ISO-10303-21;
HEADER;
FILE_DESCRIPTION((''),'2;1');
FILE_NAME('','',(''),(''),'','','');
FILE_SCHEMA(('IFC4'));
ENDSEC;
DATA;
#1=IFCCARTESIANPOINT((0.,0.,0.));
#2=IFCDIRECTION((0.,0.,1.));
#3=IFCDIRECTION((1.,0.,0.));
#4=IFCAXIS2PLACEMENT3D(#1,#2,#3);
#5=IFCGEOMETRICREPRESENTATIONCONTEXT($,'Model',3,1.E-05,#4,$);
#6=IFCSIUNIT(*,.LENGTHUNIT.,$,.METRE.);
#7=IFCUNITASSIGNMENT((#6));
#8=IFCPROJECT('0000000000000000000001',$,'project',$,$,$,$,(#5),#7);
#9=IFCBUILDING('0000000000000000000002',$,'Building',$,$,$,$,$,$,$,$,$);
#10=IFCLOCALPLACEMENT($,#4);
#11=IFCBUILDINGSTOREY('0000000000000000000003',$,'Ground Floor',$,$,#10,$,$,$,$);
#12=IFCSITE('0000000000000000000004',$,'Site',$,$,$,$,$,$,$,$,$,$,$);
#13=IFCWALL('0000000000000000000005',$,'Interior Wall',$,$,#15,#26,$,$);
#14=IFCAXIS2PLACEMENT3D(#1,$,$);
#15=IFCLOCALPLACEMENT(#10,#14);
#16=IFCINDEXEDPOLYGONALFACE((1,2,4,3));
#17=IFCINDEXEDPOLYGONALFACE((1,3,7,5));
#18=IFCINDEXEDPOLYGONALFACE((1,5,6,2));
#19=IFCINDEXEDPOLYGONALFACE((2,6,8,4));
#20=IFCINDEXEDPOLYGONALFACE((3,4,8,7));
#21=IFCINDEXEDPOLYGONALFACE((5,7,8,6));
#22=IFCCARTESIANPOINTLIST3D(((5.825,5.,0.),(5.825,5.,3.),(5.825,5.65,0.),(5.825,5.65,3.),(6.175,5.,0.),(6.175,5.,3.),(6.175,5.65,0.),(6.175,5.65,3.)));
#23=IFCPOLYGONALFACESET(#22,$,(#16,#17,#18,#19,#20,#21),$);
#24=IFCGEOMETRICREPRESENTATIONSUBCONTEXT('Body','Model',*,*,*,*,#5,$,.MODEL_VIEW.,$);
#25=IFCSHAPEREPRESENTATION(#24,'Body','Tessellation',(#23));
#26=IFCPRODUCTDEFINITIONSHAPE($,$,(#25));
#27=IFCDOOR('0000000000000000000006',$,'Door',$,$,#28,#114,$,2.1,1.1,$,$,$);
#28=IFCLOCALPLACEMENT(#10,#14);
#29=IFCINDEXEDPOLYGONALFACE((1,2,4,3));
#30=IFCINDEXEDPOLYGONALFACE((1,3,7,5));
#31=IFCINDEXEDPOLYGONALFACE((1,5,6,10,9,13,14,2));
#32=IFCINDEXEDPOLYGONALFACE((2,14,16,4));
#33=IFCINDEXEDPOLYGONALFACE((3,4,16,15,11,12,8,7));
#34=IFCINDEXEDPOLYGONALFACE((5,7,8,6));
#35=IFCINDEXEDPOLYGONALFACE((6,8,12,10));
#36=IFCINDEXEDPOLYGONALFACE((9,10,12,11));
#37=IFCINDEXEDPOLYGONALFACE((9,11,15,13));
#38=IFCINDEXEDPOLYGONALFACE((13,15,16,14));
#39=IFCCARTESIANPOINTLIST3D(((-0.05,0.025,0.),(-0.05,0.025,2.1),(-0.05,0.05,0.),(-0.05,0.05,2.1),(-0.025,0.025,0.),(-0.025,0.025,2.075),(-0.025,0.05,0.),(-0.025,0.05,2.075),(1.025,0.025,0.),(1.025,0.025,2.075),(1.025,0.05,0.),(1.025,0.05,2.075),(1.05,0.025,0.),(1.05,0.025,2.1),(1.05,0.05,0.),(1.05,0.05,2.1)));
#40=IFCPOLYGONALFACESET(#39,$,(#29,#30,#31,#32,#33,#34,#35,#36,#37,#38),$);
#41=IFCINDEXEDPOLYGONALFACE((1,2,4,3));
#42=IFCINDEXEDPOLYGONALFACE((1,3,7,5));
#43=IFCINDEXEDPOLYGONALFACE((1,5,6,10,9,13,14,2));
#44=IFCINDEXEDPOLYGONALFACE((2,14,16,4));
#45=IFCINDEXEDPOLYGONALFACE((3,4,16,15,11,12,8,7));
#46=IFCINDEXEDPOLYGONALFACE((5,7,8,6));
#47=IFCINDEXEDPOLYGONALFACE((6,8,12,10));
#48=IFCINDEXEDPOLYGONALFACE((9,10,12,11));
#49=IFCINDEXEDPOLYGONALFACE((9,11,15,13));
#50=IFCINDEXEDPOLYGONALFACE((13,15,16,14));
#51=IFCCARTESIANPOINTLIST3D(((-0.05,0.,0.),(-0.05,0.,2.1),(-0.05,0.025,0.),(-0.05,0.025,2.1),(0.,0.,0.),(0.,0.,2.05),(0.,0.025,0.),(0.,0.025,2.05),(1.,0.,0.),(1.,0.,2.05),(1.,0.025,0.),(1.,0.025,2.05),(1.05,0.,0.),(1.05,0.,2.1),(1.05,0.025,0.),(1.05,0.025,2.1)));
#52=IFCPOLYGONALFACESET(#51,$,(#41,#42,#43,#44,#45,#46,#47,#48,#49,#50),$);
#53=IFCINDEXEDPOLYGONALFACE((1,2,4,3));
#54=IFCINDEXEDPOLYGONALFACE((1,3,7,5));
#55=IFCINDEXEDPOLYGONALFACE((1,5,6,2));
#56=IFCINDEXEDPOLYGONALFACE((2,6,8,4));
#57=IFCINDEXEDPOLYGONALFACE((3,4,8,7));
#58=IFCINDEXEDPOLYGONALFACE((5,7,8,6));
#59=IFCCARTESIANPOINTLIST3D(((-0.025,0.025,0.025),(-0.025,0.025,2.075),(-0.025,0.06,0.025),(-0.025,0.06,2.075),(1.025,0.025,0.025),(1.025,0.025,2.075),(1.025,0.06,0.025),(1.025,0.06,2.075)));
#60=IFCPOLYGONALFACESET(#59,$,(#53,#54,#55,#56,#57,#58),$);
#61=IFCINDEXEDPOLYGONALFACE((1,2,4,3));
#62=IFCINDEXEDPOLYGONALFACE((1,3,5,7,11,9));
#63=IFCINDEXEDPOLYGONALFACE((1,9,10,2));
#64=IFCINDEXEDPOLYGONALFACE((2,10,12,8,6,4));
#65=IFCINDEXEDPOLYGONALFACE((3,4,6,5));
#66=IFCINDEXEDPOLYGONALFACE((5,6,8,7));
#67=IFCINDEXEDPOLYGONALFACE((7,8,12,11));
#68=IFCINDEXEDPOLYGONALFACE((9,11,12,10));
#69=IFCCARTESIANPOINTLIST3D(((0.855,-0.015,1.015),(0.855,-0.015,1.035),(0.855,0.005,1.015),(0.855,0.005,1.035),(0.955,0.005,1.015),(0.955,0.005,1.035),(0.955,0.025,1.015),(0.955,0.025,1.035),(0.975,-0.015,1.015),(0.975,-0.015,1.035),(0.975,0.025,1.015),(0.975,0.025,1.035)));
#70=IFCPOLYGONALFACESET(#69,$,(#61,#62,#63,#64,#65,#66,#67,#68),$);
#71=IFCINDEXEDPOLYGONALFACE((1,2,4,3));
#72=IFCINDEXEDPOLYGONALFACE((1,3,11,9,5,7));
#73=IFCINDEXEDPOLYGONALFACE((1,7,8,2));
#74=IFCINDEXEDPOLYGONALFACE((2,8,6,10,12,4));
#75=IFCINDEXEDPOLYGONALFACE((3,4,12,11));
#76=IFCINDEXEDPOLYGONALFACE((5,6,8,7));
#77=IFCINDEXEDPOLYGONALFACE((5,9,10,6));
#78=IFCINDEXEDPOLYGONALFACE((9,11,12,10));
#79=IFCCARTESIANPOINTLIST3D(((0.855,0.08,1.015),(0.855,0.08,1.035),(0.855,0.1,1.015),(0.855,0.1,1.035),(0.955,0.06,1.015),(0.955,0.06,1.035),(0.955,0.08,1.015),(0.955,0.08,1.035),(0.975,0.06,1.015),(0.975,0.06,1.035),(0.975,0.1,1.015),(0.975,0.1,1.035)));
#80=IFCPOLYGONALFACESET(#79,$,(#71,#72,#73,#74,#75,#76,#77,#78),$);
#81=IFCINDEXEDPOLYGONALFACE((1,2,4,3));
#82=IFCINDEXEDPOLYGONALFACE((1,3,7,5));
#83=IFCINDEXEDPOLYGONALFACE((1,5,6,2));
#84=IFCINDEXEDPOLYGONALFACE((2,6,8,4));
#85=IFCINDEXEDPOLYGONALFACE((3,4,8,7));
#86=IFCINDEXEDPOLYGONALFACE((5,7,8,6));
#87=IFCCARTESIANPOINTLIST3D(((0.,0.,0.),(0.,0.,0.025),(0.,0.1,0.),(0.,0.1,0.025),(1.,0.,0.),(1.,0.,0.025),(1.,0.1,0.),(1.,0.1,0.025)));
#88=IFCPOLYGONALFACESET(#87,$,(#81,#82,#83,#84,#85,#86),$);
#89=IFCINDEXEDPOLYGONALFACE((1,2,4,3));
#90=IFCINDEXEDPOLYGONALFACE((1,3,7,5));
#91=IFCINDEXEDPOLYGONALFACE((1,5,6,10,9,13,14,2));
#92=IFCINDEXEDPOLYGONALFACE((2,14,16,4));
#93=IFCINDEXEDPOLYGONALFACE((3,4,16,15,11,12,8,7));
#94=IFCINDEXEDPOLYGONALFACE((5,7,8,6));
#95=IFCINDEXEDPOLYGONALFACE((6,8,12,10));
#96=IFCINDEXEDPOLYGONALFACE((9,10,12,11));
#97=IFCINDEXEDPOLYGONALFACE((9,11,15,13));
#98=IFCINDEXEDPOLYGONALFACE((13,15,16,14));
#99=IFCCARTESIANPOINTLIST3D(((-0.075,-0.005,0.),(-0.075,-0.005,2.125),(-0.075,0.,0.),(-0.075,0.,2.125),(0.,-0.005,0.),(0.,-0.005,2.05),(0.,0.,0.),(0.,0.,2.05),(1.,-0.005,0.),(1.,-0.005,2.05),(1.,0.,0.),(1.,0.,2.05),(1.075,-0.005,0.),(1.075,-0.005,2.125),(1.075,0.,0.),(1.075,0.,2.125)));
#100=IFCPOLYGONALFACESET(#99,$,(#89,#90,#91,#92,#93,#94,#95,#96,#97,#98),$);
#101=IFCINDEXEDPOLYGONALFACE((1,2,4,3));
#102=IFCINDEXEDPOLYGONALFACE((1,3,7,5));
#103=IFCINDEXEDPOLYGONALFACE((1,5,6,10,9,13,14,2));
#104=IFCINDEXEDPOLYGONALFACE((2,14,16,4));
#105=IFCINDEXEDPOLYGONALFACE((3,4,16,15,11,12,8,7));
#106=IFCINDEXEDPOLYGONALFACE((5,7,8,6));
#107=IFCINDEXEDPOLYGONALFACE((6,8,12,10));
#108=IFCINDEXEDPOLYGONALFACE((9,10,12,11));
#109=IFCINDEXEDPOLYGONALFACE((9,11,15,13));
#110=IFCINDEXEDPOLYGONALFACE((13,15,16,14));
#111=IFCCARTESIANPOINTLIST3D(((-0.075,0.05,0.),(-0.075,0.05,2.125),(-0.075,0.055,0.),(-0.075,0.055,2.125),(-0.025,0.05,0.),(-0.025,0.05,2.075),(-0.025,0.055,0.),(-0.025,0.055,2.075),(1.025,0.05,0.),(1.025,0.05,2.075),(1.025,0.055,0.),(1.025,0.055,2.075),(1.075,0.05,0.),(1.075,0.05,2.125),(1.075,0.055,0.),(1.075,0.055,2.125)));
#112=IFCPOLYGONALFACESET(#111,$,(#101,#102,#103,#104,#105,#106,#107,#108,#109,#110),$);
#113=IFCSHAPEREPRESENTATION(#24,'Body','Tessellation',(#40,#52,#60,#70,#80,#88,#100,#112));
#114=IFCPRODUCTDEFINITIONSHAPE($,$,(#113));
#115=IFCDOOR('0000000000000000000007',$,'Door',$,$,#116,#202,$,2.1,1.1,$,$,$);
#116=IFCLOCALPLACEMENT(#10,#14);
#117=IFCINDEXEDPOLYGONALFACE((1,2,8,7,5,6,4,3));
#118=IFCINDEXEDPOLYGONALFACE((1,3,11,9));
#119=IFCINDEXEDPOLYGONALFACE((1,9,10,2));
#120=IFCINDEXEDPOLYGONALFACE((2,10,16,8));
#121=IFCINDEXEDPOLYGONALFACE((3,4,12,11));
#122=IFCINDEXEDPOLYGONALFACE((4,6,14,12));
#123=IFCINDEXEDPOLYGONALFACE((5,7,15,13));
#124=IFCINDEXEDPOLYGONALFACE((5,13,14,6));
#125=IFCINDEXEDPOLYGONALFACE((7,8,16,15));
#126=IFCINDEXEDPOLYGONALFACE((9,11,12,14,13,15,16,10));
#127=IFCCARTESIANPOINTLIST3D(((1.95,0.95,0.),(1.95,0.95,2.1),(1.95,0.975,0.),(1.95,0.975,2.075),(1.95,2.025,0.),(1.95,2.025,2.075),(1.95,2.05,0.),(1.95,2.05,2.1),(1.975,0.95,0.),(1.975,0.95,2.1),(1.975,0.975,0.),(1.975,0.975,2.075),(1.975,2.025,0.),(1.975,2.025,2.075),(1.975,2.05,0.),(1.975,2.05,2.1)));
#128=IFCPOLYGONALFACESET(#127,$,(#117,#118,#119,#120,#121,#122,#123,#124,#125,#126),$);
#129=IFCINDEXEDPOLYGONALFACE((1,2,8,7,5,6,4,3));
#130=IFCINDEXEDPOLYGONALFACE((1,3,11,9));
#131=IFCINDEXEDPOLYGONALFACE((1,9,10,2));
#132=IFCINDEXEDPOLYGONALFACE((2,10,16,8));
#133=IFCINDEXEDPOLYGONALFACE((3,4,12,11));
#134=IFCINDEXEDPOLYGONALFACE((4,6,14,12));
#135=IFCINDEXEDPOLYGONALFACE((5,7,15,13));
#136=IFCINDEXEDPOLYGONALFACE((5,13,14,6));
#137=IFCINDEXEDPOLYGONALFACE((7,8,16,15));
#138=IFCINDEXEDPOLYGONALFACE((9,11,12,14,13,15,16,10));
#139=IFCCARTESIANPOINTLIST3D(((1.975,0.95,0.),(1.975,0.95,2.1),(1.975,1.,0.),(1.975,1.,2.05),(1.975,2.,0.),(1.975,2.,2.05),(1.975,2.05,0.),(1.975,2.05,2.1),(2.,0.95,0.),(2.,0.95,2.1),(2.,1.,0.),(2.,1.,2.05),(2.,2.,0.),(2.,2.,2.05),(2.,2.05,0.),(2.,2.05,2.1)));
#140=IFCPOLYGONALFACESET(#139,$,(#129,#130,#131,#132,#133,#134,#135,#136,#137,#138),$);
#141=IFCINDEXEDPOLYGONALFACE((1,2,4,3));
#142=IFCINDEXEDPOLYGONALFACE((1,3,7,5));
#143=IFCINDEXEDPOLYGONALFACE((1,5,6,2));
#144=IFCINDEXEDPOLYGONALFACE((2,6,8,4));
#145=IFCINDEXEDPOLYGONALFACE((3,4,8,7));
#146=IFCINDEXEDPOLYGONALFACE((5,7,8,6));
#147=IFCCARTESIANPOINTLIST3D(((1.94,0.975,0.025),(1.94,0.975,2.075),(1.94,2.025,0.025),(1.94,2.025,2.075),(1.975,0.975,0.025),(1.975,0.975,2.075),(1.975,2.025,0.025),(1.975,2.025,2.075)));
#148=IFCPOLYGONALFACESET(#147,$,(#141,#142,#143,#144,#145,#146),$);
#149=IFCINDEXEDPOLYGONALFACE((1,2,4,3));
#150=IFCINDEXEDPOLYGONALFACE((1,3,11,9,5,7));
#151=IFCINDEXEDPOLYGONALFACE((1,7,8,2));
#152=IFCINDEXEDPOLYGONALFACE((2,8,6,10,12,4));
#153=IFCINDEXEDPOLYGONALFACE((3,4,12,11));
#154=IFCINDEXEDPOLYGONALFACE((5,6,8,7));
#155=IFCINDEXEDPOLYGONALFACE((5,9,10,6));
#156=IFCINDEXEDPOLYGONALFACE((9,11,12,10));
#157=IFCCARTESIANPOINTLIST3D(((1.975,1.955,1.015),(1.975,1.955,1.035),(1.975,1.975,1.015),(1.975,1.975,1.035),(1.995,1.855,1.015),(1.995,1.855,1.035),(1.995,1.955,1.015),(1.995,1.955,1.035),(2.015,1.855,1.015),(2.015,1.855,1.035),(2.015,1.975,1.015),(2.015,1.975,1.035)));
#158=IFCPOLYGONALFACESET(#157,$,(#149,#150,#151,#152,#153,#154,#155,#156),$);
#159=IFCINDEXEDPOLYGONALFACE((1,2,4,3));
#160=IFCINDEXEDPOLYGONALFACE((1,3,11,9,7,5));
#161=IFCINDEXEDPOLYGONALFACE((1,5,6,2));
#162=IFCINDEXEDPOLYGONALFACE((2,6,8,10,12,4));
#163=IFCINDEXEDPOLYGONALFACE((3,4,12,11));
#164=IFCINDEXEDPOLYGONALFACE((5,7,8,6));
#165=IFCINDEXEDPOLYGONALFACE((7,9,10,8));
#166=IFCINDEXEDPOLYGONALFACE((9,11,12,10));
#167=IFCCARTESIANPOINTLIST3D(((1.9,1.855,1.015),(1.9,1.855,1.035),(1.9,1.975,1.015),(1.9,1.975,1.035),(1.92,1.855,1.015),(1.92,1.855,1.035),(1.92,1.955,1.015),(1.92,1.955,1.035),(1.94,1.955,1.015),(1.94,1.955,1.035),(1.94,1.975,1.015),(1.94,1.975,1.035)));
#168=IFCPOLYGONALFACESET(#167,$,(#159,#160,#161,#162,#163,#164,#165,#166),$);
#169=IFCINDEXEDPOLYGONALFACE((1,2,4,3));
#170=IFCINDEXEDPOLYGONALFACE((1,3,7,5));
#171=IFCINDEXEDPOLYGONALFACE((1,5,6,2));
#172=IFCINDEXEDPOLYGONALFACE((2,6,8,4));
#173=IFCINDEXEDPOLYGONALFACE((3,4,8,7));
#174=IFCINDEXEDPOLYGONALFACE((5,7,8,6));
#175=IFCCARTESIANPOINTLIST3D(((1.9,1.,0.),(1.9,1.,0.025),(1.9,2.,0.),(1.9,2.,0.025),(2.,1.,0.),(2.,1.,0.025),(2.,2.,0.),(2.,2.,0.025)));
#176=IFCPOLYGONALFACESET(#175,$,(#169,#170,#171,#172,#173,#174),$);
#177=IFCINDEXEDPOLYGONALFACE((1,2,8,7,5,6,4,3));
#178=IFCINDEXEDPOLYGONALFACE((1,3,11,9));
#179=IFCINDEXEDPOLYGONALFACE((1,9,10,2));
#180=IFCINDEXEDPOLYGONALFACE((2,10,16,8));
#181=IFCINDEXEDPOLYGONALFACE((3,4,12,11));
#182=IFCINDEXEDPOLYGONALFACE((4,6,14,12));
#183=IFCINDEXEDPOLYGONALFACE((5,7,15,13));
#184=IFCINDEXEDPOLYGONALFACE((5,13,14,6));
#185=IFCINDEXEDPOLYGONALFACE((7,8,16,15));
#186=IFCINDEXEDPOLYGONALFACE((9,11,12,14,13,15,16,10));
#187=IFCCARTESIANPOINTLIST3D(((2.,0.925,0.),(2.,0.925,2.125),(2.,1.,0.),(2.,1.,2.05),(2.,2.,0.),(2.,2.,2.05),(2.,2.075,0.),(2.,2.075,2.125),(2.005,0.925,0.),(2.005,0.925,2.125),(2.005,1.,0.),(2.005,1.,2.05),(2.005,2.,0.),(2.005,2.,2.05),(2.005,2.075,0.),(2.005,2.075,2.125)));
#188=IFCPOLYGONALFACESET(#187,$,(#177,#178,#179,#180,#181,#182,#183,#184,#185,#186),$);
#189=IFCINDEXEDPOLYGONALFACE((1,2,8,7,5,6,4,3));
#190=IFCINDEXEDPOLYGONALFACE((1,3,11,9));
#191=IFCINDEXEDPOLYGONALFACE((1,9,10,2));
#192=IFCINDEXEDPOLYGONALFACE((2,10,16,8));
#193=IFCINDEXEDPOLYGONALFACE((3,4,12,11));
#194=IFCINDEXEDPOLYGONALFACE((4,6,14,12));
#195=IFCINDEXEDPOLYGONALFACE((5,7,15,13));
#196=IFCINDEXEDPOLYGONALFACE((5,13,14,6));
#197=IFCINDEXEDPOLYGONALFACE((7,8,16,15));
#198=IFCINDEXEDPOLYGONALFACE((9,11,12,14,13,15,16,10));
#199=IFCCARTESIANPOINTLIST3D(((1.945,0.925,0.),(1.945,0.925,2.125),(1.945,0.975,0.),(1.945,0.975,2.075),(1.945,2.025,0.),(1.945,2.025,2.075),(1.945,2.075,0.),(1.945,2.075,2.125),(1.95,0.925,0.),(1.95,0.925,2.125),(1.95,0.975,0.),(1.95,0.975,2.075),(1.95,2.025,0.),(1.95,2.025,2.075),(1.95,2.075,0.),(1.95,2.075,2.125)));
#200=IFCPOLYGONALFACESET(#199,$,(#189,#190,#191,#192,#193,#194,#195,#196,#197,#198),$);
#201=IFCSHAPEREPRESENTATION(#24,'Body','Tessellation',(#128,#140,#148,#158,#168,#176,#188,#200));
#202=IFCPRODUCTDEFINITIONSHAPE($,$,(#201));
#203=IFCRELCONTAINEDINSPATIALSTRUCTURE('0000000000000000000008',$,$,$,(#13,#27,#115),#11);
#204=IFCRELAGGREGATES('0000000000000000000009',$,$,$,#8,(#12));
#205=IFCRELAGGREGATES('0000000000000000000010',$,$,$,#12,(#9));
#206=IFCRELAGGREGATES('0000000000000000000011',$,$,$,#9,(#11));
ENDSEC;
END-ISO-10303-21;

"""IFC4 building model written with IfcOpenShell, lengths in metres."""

from ifc_helpers import new_model, si_unit, frame, origin_with_axes, place, context, subcontext, project, spatial, line, indexed_curve, outline, extrude, element, save


model = new_model("IFC4")

# Units and contexts
model_context = context("Model", 3, precision=1e-05, world=origin_with_axes())
body_context = subcontext(model_context, "Body", "Model", "MODEL_VIEW")
ifc_project = project(units=[si_unit("LENGTHUNIT", "METRE")], contexts=[model_context])

# Site, building, storey
site = spatial("IfcSite", under=ifc_project, Name="Site")
building = spatial("IfcBuilding", under=site, Name="Building")
storey_placement = place(None, origin_with_axes())
storey = spatial("IfcBuildingStorey", under=building, at=storey_placement, Name="Ground Floor")

# Wall
wall_1_placement = place(storey_placement, frame((6.0, 5.0, 0.0), z_axis=(0.0, 0.0, 1.0), x_axis=(0.0, 1.0, 0.0)))
element("IfcWall", 1, at=wall_1_placement, inside=storey, Name="Interior Wall", context=body_context, shape_type="SweptSolid", body=[
    extrude(outline(indexed_curve([(0.0, 0.0), (0.0, 0.35), (0.65, 0.35), (0.65, 0.0), (0.0, 0.0)], self_intersect=False)), frame((0.0, -0.175, 0.0), z_axis=(0.0, 0.0, 1.0), x_axis=(1.0, 0.0, 0.0)), (0.0, 0.0, 1.0), 3.0),
])

# Doors
door_1_placement = place(storey_placement, frame((-0.05, 0.0, 0.0), z_axis=(0.0, 0.0, 1.0), x_axis=(1.0, 0.0, 0.0)))
element("IfcDoor", 2, at=door_1_placement, inside=storey, Name="Door", OverallHeight=2.1, OverallWidth=1.1, context=body_context, shape_type="SweptSolid", body=[
    extrude(outline(indexed_curve([(0.0, 0.0), (0.0, 2.1), (1.1, 2.1), (1.1, 0.0), (1.075, 0.0), (1.075, 2.075), (0.025, 2.075), (0.025, 0.0)], segments=[line(1, 2, 3, 4, 5, 6, 7, 8, 1)])), frame((0.0, 0.025, 0.0), z_axis=(0.0, -1.0, 0.0), x_axis=(1.0, 0.0, 0.0)), (0.0, 0.0, -1.0), 0.025),
    extrude(outline(indexed_curve([(0.0, 0.0), (0.0, 2.1), (1.1, 2.1), (1.1, 0.0), (1.05, 0.0), (1.05, 2.05), (0.05, 2.05), (0.05, 0.0)], segments=[line(1, 2, 3, 4, 5, 6, 7, 8, 1)])), frame((0.0, 0.0, 0.0), z_axis=(0.0, -1.0, 0.0), x_axis=(1.0, 0.0, 0.0)), (0.0, 0.0, -1.0), 0.025),
    extrude(outline(indexed_curve([(0.0, 0.0), (1.05, 0.0), (1.05, 0.035), (0.0, 0.035)], segments=[line(1, 2, 3, 4, 1)])), frame((0.025, 0.025, 0.025), z_axis=(0.0, 0.0, 1.0), x_axis=(1.0, 0.0, 0.0)), (0.0, 0.0, 1.0), 2.05),
    extrude(outline(indexed_curve([(0.0, 0.0), (0.0, -0.04), (-0.12, -0.04), (-0.12, -0.02), (-0.02, -0.02), (-0.02, 0.0)], segments=[line(1, 2, 3, 4, 5, 6, 1)])), frame((1.025, 0.025, 1.015), z_axis=(0.0, 0.0, 1.0), x_axis=(1.0, 0.0, 0.0)), (0.0, 0.0, 1.0), 0.02),
    extrude(outline(indexed_curve([(0.0, 0.0), (0.0, 0.04), (-0.12, 0.04), (-0.12, 0.02), (-0.02, 0.02), (-0.02, 0.0)], segments=[line(1, 2, 3, 4, 5, 6, 1)])), frame((1.025, 0.06, 1.015), z_axis=(0.0, 0.0, 1.0), x_axis=(1.0, 0.0, 0.0)), (0.0, 0.0, 1.0), 0.02),
    extrude(outline(indexed_curve([(0.0, 0.0), (1.0, 0.0), (1.0, 0.1), (0.0, 0.1)], segments=[line(1, 2, 3, 4, 1)])), frame((0.05, 0.0, 0.0), z_axis=(0.0, 0.0, 1.0), x_axis=(1.0, 0.0, 0.0)), (0.0, 0.0, 1.0), 0.025),
    extrude(outline(indexed_curve([(0.0, 0.0), (0.0, 2.125), (1.15, 2.125), (1.15, 0.0), (1.075, 0.0), (1.075, 2.05), (0.075, 2.05), (0.075, 0.0)], segments=[line(1, 2, 3, 4, 5, 6, 7, 8, 1)])), frame((-0.025, -0.005, 0.0), z_axis=(0.0, -1.0, 0.0), x_axis=(1.0, 0.0, 0.0)), (0.0, 0.0, -1.0), 0.005),
    extrude(outline(indexed_curve([(0.0, 0.0), (0.0, 2.125), (1.15, 2.125), (1.15, 0.0), (1.1, 0.0), (1.1, 2.075), (0.05, 2.075), (0.05, 0.0)], segments=[line(1, 2, 3, 4, 5, 6, 7, 8, 1)])), frame((-0.025, 0.05, 0.0), z_axis=(0.0, -1.0, 0.0), x_axis=(1.0, 0.0, 0.0)), (0.0, 0.0, -1.0), 0.005),
])
door_2_placement = place(storey_placement, frame((2.0, 0.95, 0.0), z_axis=(0.0, 0.0, 1.0), x_axis=(0.0, 1.0, 0.0)))
element("IfcDoor", 3, at=door_2_placement, inside=storey, Name="Door", OverallHeight=2.1, OverallWidth=1.1, context=body_context, shape_type="SweptSolid", body=[
    extrude(outline(indexed_curve([(0.0, 0.0), (0.0, 2.1), (1.1, 2.1), (1.1, 0.0), (1.075, 0.0), (1.075, 2.075), (0.025, 2.075), (0.025, 0.0)], segments=[line(1, 2, 3, 4, 5, 6, 7, 8, 1)])), frame((0.0, 0.025, 0.0), z_axis=(0.0, -1.0, 0.0), x_axis=(1.0, 0.0, 0.0)), (0.0, 0.0, -1.0), 0.025),
    extrude(outline(indexed_curve([(0.0, 0.0), (0.0, 2.1), (1.1, 2.1), (1.1, 0.0), (1.05, 0.0), (1.05, 2.05), (0.05, 2.05), (0.05, 0.0)], segments=[line(1, 2, 3, 4, 5, 6, 7, 8, 1)])), frame((0.0, 0.0, 0.0), z_axis=(0.0, -1.0, 0.0), x_axis=(1.0, 0.0, 0.0)), (0.0, 0.0, -1.0), 0.025),
    extrude(outline(indexed_curve([(0.0, 0.0), (1.05, 0.0), (1.05, 0.035), (0.0, 0.035)], segments=[line(1, 2, 3, 4, 1)])), frame((0.025, 0.025, 0.025), z_axis=(0.0, 0.0, 1.0), x_axis=(1.0, 0.0, 0.0)), (0.0, 0.0, 1.0), 2.05),
    extrude(outline(indexed_curve([(0.0, 0.0), (0.0, -0.04), (-0.12, -0.04), (-0.12, -0.02), (-0.02, -0.02), (-0.02, 0.0)], segments=[line(1, 2, 3, 4, 5, 6, 1)])), frame((1.025, 0.025, 1.015), z_axis=(0.0, 0.0, 1.0), x_axis=(1.0, 0.0, 0.0)), (0.0, 0.0, 1.0), 0.02),
    extrude(outline(indexed_curve([(0.0, 0.0), (0.0, 0.04), (-0.12, 0.04), (-0.12, 0.02), (-0.02, 0.02), (-0.02, 0.0)], segments=[line(1, 2, 3, 4, 5, 6, 1)])), frame((1.025, 0.06, 1.015), z_axis=(0.0, 0.0, 1.0), x_axis=(1.0, 0.0, 0.0)), (0.0, 0.0, 1.0), 0.02),
    extrude(outline(indexed_curve([(0.0, 0.0), (1.0, 0.0), (1.0, 0.1), (0.0, 0.1)], segments=[line(1, 2, 3, 4, 1)])), frame((0.05, 0.0, 0.0), z_axis=(0.0, 0.0, 1.0), x_axis=(1.0, 0.0, 0.0)), (0.0, 0.0, 1.0), 0.025),
    extrude(outline(indexed_curve([(0.0, 0.0), (0.0, 2.125), (1.15, 2.125), (1.15, 0.0), (1.075, 0.0), (1.075, 2.05), (0.075, 2.05), (0.075, 0.0)], segments=[line(1, 2, 3, 4, 5, 6, 7, 8, 1)])), frame((-0.025, -0.005, 0.0), z_axis=(0.0, -1.0, 0.0), x_axis=(1.0, 0.0, 0.0)), (0.0, 0.0, -1.0), 0.005),
    extrude(outline(indexed_curve([(0.0, 0.0), (0.0, 2.125), (1.15, 2.125), (1.15, 0.0), (1.1, 0.0), (1.1, 2.075), (0.05, 2.075), (0.05, 0.0)], segments=[line(1, 2, 3, 4, 5, 6, 7, 8, 1)])), frame((-0.025, 0.05, 0.0), z_axis=(0.0, -1.0, 0.0), x_axis=(1.0, 0.0, 0.0)), (0.0, 0.0, -1.0), 0.005),
])

save(model, "model.ifc")
